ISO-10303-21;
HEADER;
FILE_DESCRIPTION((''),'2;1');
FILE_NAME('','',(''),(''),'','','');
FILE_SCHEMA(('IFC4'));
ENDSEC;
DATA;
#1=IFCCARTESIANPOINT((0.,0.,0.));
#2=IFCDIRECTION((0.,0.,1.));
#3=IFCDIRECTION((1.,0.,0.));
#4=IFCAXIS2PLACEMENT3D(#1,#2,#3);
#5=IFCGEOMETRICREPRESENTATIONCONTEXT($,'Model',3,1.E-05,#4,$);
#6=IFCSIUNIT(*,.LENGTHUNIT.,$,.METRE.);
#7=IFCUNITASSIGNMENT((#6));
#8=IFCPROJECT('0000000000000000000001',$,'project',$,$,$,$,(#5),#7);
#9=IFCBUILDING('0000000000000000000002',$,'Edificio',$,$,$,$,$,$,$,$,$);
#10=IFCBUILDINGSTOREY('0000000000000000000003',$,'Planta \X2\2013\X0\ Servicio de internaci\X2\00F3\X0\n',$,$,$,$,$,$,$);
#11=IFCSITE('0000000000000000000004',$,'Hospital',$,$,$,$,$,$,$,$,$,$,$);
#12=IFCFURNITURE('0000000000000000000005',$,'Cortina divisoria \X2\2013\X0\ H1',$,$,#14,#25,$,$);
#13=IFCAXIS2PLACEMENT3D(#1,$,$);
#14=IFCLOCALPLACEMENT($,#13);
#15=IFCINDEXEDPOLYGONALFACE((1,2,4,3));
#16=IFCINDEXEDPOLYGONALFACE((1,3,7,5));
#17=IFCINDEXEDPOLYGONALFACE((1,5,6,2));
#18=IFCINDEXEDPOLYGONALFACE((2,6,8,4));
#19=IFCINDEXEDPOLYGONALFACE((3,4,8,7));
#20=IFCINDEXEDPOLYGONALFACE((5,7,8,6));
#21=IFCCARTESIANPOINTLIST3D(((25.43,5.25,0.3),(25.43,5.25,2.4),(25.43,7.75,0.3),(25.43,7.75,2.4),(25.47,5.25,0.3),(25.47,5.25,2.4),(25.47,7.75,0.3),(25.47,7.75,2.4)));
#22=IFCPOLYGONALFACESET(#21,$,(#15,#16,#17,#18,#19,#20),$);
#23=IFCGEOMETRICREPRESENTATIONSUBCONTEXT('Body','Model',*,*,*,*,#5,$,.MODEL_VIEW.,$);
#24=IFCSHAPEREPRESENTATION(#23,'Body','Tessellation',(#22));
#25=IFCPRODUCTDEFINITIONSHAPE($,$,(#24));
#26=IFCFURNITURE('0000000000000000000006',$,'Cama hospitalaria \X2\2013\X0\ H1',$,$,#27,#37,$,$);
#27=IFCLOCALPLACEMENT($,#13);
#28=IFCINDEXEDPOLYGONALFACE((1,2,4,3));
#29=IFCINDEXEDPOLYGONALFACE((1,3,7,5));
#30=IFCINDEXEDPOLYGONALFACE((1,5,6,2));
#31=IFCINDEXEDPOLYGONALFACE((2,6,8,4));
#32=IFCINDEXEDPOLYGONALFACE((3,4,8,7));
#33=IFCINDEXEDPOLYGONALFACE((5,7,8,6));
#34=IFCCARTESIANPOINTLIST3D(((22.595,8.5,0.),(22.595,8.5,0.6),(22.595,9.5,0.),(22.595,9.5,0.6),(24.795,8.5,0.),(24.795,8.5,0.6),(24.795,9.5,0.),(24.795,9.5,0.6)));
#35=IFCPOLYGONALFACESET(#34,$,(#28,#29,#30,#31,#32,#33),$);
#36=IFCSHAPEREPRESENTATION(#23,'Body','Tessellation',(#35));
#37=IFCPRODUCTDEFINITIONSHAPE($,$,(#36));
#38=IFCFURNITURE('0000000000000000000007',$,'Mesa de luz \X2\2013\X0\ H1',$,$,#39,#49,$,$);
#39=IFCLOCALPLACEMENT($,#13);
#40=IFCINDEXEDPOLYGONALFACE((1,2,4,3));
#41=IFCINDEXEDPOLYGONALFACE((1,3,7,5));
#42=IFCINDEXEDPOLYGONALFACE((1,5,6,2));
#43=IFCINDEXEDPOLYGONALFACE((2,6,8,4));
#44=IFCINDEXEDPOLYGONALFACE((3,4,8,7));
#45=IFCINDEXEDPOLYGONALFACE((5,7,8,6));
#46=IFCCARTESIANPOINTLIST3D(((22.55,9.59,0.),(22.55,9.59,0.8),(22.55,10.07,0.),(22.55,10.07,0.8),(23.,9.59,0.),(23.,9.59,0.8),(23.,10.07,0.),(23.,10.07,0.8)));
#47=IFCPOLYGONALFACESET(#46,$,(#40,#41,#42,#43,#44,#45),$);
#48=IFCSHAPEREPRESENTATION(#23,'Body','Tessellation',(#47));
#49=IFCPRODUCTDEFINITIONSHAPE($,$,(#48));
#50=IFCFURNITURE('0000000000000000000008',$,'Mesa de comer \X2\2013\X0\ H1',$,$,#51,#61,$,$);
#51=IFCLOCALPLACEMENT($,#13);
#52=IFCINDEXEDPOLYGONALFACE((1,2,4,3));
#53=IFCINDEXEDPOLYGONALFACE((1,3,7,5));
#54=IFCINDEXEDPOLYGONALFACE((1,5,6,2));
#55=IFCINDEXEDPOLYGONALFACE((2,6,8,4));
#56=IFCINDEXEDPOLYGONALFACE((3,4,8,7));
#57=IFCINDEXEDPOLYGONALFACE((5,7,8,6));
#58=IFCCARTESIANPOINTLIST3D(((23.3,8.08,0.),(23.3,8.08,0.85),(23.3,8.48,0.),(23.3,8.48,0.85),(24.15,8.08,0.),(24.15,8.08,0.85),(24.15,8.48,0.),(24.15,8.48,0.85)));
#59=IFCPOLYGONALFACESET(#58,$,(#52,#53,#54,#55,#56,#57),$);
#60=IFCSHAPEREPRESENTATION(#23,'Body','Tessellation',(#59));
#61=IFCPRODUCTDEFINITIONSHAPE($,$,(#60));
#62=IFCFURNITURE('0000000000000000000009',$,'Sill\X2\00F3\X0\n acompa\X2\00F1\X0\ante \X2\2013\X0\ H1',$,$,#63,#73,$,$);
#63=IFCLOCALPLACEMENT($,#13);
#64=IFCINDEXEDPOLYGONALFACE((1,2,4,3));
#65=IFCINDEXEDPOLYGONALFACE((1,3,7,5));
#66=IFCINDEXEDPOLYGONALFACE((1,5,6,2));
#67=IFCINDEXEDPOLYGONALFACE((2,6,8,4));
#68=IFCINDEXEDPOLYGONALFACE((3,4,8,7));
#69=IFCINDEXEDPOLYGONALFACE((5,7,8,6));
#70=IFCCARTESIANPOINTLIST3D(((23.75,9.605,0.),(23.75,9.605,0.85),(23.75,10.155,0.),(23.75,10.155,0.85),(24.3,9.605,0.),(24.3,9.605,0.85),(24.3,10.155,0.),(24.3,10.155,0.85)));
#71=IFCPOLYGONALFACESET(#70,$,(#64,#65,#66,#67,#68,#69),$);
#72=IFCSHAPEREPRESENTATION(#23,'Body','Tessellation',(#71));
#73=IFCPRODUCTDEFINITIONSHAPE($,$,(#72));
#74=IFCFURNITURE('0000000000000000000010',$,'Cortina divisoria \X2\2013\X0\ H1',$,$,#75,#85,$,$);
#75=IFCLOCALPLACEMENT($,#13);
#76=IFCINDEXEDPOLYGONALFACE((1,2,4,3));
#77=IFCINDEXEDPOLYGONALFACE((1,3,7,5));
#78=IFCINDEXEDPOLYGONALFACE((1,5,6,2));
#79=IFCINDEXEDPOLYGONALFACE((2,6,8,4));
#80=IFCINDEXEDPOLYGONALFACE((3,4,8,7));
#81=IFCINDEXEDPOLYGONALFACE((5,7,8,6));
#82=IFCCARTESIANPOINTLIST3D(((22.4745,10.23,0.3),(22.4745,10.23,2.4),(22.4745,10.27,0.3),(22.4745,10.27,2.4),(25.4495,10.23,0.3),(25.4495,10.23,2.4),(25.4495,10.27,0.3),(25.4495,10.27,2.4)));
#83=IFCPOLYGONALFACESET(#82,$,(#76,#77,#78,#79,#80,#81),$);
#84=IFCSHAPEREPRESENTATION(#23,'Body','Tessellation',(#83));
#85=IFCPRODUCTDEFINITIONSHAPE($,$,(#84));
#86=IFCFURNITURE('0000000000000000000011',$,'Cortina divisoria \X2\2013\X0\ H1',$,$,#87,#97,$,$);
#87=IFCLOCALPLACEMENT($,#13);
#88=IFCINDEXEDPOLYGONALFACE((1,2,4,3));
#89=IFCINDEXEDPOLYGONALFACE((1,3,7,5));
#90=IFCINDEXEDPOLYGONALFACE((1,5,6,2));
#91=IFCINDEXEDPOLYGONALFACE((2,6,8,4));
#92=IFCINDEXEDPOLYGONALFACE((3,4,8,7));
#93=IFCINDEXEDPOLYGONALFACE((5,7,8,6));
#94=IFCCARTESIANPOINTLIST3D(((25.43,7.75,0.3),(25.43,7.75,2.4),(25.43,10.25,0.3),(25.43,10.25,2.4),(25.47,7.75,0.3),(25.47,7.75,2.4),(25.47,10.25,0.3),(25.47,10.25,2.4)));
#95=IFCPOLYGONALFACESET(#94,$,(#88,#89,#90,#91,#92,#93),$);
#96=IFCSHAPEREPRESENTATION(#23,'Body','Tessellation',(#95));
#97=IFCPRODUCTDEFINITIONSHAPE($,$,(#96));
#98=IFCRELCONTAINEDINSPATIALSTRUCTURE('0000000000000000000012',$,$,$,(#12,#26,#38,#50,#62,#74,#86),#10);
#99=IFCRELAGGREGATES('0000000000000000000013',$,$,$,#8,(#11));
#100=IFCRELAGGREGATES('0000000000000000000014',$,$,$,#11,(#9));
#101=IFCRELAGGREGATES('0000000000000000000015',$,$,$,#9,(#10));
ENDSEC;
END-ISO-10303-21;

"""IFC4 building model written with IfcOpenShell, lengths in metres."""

from ifc_helpers import new_model, si_unit, frame, origin_with_axes, context, subcontext, project, spatial, line, indexed_curve, outline, extrude, element, save


model = new_model("IFC4")

# Units and contexts
model_context = context("Model", 3, precision=1e-05, world=origin_with_axes())
body_context = subcontext(model_context, "Body", "Model", "MODEL_VIEW")
ifc_project = project(units=[si_unit("LENGTHUNIT", "METRE")], contexts=[model_context])

# Site, building, storey
site = spatial("IfcSite", under=ifc_project, Name="Hospital")
building = spatial("IfcBuilding", under=site, Name="Edificio")
storey = spatial("IfcBuildingStorey", under=building, Name="Planta – Servicio de internación")

# Furniture
element("IfcFurniture", 1, inside=storey, Name="Cortina divisoria – H1", context=body_context, shape_type="SweptSolid", body=[
    extrude(outline(indexed_curve([(0.0, 0.0), (0.04, 0.0), (0.04, 2.5), (0.0, 2.5)], segments=[line(1, 2, 3, 4, 1)])), frame((25.43, 5.25, 0.3), z_axis=(0.0, 0.0, 1.0), x_axis=(1.0, 0.0, 0.0)), (0.0, 0.0, 1.0), 2.1),
])
element("IfcFurniture", 2, inside=storey, Name="Cama hospitalaria – H1", context=body_context, shape_type="SweptSolid", body=[
    extrude(outline(indexed_curve([(0.0, 0.0), (2.2, 0.0), (2.2, 1.0), (0.0, 1.0)], segments=[line(1, 2, 3, 4, 1)])), frame((22.595, 8.5, 0.0), z_axis=(0.0, 0.0, 1.0), x_axis=(1.0, 0.0, 0.0)), (0.0, 0.0, 1.0), 0.6),
])
element("IfcFurniture", 3, inside=storey, Name="Mesa de luz – H1", context=body_context, shape_type="SweptSolid", body=[
    extrude(outline(indexed_curve([(0.0, 0.0), (0.45, 0.0), (0.45, 0.48), (0.0, 0.48)], segments=[line(1, 2, 3, 4, 1)])), frame((22.55, 9.59, 0.0), z_axis=(0.0, 0.0, 1.0), x_axis=(1.0, 0.0, 0.0)), (0.0, 0.0, 1.0), 0.8),
])
element("IfcFurniture", 4, inside=storey, Name="Mesa de comer – H1", context=body_context, shape_type="SweptSolid", body=[
    extrude(outline(indexed_curve([(0.0, 0.0), (0.85, 0.0), (0.85, 0.4), (0.0, 0.4)], segments=[line(1, 2, 3, 4, 1)])), frame((23.3, 8.08, 0.0), z_axis=(0.0, 0.0, 1.0), x_axis=(1.0, 0.0, 0.0)), (0.0, 0.0, 1.0), 0.85),
])
element("IfcFurniture", 5, inside=storey, Name="Sillón acompañante – H1", context=body_context, shape_type="SweptSolid", body=[
    extrude(outline(indexed_curve([(0.0, 0.0), (0.55, 0.0), (0.55, 0.55), (0.0, 0.55)], segments=[line(1, 2, 3, 4, 1)])), frame((23.75, 9.605, 0.0), z_axis=(0.0, 0.0, 1.0), x_axis=(1.0, 0.0, 0.0)), (0.0, 0.0, 1.0), 0.85),
])
element("IfcFurniture", 6, inside=storey, Name="Cortina divisoria – H1", context=body_context, shape_type="SweptSolid", body=[
    extrude(outline(indexed_curve([(0.0, 0.0), (2.975, 0.0), (2.975, 0.04), (0.0, 0.04)], segments=[line(1, 2, 3, 4, 1)])), frame((22.4745, 10.23, 0.3), z_axis=(0.0, 0.0, 1.0), x_axis=(1.0, 0.0, 0.0)), (0.0, 0.0, 1.0), 2.1),
])
element("IfcFurniture", 7, inside=storey, Name="Cortina divisoria – H1", context=body_context, shape_type="SweptSolid", body=[
    extrude(outline(indexed_curve([(0.0, 0.0), (0.04, 0.0), (0.04, 2.5), (0.0, 2.5)], segments=[line(1, 2, 3, 4, 1)])), frame((25.43, 7.75, 0.3), z_axis=(0.0, 0.0, 1.0), x_axis=(1.0, 0.0, 0.0)), (0.0, 0.0, 1.0), 2.1),
])

save(model, "model.ifc")
